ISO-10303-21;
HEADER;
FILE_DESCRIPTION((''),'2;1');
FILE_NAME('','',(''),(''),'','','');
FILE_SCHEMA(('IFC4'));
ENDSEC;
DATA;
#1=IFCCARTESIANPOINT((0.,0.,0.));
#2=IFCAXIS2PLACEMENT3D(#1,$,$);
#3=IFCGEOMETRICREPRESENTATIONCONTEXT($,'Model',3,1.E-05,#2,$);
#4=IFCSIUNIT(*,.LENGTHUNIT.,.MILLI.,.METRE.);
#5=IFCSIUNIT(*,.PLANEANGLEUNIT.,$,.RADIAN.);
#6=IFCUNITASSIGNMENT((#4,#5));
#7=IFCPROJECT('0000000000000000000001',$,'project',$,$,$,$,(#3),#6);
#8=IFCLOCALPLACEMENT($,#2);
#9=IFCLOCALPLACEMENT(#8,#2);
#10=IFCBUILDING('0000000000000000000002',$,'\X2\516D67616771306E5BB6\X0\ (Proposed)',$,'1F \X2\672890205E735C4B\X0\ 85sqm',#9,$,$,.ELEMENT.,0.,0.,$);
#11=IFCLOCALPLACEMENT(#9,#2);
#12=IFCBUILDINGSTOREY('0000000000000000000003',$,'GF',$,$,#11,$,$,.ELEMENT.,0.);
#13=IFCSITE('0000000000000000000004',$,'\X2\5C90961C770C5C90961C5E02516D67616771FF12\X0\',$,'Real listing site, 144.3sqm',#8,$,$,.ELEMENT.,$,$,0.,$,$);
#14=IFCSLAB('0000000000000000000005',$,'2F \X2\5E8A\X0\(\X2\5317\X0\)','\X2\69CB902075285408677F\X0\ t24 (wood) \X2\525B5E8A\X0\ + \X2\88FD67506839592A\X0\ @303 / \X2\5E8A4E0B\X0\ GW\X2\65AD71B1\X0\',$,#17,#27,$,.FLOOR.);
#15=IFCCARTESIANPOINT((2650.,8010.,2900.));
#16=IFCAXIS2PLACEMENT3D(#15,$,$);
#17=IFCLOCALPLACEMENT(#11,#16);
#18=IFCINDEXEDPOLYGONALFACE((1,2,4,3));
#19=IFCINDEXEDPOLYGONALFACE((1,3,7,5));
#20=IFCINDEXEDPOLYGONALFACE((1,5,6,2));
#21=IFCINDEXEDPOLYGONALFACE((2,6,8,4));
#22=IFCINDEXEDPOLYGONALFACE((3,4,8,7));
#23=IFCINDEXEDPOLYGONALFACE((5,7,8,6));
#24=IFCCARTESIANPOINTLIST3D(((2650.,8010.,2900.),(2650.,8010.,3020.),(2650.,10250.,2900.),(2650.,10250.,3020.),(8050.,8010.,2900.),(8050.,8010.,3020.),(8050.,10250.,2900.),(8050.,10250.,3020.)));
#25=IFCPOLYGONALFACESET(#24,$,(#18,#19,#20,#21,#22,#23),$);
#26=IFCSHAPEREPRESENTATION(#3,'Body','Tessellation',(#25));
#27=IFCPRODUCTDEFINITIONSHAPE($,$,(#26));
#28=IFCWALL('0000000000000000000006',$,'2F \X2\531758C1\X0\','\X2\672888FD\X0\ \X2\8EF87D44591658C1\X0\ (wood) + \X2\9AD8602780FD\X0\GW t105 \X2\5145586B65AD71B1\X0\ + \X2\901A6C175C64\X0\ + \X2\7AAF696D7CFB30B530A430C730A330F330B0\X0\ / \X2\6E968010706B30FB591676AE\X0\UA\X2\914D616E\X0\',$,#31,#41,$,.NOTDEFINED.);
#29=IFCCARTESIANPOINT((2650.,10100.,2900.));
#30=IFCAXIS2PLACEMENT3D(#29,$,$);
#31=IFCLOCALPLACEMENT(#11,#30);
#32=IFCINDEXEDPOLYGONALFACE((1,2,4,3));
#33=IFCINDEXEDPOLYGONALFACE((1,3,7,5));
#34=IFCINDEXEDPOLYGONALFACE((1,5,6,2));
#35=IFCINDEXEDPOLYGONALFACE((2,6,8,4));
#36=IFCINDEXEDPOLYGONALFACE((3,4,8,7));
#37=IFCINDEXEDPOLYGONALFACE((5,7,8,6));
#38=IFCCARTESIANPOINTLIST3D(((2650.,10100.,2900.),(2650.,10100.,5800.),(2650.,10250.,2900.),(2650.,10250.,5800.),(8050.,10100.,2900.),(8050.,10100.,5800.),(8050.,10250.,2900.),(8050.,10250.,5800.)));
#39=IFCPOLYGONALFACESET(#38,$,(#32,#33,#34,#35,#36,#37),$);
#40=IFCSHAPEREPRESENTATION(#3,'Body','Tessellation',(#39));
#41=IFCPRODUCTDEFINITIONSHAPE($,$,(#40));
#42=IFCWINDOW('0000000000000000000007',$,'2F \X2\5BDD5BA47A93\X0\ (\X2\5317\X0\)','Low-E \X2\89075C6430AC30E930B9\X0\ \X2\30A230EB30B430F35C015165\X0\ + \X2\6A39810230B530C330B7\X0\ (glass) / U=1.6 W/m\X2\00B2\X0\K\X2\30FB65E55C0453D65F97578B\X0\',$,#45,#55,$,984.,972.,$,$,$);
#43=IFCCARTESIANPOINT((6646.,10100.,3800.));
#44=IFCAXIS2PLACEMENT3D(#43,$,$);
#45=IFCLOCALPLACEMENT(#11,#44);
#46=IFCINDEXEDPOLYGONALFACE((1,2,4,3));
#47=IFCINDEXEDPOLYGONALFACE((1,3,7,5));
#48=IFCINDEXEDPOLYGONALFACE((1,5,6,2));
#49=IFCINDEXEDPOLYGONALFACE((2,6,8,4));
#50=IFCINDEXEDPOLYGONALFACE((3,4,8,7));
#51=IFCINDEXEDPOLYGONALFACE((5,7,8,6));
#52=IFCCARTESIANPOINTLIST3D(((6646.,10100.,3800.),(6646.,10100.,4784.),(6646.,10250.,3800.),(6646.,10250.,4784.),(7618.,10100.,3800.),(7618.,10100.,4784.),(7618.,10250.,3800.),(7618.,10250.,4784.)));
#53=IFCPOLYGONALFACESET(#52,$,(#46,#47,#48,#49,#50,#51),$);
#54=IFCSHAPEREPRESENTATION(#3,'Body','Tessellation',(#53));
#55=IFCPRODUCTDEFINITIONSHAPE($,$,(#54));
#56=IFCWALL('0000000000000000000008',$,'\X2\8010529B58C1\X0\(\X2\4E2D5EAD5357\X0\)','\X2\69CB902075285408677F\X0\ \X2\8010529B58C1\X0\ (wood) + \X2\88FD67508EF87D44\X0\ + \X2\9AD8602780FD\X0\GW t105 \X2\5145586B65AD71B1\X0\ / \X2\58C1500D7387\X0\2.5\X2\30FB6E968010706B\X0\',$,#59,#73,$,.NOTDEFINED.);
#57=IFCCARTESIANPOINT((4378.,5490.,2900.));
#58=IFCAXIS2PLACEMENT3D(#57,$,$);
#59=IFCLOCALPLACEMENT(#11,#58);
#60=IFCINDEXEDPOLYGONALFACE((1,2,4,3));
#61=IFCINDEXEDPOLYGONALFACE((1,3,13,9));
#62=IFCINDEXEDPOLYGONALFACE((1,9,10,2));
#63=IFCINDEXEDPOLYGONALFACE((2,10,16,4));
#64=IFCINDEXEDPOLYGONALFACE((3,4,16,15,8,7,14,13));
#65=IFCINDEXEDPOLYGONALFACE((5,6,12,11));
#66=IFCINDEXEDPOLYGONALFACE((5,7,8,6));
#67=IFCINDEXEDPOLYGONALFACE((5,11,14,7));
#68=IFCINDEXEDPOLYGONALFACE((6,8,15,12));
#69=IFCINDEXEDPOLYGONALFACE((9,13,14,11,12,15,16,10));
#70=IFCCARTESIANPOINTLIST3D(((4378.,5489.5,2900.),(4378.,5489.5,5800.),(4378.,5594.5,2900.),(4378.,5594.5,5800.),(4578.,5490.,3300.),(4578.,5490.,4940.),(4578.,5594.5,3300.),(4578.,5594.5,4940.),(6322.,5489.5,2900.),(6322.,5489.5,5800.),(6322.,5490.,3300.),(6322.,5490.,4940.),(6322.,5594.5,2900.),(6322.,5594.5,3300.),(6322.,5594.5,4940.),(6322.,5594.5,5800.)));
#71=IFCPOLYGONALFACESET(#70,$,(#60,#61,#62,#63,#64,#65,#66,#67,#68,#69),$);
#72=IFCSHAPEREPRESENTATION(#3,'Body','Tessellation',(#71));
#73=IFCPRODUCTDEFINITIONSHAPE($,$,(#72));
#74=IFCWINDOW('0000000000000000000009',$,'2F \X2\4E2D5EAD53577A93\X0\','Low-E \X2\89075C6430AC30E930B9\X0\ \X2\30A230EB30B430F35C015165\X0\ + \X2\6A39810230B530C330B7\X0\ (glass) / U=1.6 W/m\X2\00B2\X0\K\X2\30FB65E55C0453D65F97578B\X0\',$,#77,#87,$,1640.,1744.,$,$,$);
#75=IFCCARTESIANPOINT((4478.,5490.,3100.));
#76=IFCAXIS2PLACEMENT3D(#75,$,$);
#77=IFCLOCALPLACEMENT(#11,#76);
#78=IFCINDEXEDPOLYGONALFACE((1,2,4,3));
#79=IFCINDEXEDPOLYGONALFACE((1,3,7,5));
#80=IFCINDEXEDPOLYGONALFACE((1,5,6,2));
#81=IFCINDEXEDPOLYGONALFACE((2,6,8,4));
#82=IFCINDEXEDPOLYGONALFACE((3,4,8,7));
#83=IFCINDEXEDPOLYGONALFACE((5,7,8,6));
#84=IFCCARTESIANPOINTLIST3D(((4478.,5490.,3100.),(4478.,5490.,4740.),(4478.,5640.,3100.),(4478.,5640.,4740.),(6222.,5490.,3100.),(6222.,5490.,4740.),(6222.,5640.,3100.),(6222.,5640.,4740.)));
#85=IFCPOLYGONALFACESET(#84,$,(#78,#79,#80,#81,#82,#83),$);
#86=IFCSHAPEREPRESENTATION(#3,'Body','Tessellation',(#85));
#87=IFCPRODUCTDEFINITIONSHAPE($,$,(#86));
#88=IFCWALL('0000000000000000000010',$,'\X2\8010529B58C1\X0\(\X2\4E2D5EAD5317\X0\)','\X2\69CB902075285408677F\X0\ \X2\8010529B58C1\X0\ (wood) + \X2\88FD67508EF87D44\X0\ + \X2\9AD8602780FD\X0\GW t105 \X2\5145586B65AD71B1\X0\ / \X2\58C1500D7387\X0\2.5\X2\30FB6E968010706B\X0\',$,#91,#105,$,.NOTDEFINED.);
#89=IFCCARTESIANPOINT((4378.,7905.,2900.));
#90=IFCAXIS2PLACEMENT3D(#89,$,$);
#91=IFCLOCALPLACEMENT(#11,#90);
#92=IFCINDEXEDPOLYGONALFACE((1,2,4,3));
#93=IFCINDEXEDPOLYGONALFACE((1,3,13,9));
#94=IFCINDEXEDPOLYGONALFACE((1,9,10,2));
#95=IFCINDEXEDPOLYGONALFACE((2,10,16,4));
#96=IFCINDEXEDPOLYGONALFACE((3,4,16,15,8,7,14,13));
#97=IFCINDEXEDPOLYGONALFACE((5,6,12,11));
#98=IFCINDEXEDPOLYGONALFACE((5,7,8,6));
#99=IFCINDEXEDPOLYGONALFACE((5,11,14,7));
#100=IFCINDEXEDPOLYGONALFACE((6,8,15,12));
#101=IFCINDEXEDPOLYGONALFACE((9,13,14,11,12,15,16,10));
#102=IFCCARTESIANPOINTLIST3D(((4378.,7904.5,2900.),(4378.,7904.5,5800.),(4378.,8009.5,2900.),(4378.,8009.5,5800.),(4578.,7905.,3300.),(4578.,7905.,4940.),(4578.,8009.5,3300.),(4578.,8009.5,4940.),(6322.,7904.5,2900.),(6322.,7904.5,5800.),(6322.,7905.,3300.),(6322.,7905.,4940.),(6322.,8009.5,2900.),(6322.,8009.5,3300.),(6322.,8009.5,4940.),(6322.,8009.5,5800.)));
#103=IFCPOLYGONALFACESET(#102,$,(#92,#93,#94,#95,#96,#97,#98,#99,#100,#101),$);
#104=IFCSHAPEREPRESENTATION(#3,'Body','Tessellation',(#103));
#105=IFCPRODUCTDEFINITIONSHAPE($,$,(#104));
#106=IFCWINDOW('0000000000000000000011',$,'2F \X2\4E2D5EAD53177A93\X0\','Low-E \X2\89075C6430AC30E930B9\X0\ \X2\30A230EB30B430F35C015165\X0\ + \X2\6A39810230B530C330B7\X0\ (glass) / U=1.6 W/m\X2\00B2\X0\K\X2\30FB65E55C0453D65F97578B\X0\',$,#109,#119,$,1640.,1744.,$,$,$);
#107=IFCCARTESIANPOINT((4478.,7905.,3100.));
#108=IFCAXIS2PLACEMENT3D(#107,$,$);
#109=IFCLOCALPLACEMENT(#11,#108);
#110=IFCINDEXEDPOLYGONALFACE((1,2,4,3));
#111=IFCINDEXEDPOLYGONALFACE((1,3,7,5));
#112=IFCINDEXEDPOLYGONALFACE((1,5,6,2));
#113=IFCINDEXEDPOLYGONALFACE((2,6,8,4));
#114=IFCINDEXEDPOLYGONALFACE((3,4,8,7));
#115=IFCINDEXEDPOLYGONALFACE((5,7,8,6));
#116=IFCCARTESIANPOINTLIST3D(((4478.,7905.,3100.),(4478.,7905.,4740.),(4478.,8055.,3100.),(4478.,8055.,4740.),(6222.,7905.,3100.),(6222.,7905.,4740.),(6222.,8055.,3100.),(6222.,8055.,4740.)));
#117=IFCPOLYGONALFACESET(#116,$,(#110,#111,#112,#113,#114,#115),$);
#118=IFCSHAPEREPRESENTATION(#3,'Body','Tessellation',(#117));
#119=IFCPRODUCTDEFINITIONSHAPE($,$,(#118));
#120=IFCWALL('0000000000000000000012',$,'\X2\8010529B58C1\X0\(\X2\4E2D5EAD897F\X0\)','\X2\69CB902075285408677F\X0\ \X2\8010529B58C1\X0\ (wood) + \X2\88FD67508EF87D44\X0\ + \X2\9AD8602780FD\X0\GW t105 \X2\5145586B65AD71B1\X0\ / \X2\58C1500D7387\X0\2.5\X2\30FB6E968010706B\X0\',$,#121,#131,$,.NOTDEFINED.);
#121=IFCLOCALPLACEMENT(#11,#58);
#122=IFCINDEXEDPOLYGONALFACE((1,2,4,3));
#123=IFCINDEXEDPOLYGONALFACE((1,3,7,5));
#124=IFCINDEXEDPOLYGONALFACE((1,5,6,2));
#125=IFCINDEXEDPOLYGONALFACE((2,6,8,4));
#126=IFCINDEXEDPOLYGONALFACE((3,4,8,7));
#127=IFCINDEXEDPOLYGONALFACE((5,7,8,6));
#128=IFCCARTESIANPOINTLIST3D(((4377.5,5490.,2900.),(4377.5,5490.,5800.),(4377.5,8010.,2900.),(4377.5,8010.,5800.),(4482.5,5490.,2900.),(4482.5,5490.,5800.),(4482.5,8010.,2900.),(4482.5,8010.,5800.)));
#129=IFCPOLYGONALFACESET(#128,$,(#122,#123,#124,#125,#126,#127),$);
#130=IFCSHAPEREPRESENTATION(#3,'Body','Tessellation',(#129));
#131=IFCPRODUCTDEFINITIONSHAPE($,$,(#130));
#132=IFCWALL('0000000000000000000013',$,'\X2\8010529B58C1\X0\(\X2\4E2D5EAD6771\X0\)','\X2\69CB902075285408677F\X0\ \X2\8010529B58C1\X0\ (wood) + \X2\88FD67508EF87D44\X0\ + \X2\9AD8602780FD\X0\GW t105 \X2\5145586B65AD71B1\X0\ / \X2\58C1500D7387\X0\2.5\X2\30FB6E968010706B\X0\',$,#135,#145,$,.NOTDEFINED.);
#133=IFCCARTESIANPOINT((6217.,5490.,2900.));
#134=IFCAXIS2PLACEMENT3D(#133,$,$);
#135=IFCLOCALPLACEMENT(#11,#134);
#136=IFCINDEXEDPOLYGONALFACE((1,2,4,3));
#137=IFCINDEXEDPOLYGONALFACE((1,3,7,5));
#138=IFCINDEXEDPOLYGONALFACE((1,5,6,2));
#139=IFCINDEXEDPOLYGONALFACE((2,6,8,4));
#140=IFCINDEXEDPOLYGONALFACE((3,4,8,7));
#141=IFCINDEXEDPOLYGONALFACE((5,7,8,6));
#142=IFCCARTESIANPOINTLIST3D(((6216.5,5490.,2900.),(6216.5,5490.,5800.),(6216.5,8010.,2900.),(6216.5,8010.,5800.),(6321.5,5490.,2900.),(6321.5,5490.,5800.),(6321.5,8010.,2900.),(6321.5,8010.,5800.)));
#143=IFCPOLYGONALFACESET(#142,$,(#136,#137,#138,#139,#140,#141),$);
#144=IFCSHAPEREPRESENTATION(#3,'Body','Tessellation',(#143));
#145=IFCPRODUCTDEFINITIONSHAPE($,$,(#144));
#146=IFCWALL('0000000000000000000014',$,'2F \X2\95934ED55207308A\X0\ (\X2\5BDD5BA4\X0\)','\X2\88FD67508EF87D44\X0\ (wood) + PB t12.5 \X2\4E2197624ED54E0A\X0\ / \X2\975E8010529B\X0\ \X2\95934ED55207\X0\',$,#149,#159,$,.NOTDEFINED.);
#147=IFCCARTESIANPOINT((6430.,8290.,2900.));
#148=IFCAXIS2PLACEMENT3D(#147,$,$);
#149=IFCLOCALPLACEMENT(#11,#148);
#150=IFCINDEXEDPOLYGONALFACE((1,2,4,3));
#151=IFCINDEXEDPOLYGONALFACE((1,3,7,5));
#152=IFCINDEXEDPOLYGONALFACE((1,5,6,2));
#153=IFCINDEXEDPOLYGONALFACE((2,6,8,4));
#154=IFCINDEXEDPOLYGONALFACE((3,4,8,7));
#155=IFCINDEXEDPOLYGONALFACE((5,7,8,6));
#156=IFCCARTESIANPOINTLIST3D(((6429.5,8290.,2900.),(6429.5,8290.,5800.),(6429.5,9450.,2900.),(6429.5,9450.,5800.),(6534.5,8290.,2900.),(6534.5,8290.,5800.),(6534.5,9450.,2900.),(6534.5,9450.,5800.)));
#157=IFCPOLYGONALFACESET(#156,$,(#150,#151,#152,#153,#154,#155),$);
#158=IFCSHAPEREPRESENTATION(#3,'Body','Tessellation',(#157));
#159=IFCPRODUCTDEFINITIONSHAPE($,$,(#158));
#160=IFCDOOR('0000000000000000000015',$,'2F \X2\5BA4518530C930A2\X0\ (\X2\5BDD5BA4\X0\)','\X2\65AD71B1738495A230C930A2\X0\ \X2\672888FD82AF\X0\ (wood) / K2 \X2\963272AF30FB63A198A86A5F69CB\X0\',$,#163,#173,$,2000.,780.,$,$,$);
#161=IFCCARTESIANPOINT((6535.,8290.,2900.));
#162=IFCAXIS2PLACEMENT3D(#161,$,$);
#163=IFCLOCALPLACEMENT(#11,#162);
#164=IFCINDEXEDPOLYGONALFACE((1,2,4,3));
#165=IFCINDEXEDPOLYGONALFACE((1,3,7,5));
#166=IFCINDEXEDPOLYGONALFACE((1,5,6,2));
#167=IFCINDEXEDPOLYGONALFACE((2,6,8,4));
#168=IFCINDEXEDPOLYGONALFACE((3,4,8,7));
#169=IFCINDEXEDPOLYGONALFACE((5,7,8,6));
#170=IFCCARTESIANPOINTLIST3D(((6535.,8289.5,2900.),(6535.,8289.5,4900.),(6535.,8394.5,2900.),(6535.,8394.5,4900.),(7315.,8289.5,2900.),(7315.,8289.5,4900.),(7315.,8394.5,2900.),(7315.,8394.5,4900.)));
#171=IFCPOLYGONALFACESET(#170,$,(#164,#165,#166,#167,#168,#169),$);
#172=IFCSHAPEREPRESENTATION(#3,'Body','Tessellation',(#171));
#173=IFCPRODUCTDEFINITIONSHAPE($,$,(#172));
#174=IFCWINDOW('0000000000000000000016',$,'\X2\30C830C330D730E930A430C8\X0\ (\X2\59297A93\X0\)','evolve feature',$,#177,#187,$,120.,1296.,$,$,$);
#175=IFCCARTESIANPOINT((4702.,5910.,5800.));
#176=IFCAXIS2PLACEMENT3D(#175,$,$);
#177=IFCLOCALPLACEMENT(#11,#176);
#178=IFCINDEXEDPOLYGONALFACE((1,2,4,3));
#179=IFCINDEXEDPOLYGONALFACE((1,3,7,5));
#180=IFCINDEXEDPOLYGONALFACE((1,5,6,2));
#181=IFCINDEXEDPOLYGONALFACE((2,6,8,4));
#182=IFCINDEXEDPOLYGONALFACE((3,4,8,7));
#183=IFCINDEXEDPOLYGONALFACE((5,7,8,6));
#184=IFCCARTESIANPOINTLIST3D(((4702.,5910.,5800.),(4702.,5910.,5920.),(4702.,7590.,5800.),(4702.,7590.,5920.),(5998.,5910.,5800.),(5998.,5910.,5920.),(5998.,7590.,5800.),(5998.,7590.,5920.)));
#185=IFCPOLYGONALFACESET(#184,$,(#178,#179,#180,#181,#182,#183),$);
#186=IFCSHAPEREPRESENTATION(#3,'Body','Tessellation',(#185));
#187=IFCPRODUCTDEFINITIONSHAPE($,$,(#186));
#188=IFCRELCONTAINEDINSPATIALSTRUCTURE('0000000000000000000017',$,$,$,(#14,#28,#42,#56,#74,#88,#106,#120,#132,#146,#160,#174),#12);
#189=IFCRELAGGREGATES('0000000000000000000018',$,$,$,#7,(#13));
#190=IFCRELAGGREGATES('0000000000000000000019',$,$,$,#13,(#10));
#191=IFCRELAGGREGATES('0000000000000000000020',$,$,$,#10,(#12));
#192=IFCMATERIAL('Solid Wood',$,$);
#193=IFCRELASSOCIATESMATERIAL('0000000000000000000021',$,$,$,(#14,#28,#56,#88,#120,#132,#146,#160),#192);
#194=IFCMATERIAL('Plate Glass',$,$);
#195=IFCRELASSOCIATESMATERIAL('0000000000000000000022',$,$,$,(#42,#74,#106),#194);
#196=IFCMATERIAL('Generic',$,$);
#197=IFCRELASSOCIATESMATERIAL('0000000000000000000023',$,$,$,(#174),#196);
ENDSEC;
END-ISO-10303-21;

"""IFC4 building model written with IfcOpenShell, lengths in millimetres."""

from ifc_helpers import new_model, si_unit, frame, frame_2d, origin, place, context, project, spatial, rectangle, extrude, material, element, fill, save


model = new_model("IFC4")

# Units and contexts
model_context = context("Model", 3, precision=1e-05, world=origin())
ifc_project = project(units=[si_unit("LENGTHUNIT", "METRE", prefix="MILLI"), si_unit("PLANEANGLEUNIT", "RADIAN")], contexts=[model_context])

# Site, building, storey
site_placement = place(None, origin())
site = spatial("IfcSite", under=ifc_project, at=site_placement, Name="岐阜県岐阜市六条東２", ObjectType="Real listing site, 144.3sqm", CompositionType="ELEMENT", RefElevation=0.0)
building_placement = place(site_placement, origin())
building = spatial("IfcBuilding", under=site, at=building_placement, Name="六条東の家 (Proposed)", ObjectType="1F 木造平屋 85sqm", CompositionType="ELEMENT", ElevationOfRefHeight=0.0, ElevationOfTerrain=0.0)
storey_placement = place(building_placement, origin())
storey = spatial("IfcBuildingStorey", under=building, at=storey_placement, Name="GF", CompositionType="ELEMENT", Elevation=0.0)

# Slab
ifc_material_1 = material(Name="Solid Wood")
slab_placement = place(storey_placement, frame((2650.0, 8010.0, 2900.0)))
element("IfcSlab", 1, at=slab_placement, inside=storey, material=ifc_material_1, Name="2F 床(北)", Description="構造用合板 t24 (wood) 剛床 + 製材根太 @303 / 床下 GW断熱", PredefinedType="FLOOR", context=model_context, shape_type="SweptSolid", body=[
    extrude(rectangle(XDim=5400.0, YDim=2240.0, at=frame_2d((2700.0, 1120.0))), frame((2650.0, 8010.0, 2900.0)), (0.0, 0.0, 1.0), 120.0),
])

# Walls, openings, windows
wall_1_placement = place(storey_placement, frame((2650.0, 10100.0, 2900.0)))
wall_1 = element("IfcWall", 2, at=wall_1_placement, inside=storey, material=ifc_material_1, Name="2F 北壁", Description="木製 軸組外壁 (wood) + 高性能GW t105 充填断熱 + 通気層 + 窯業系サイディング / 準耐火・外皮UA配慮", PredefinedType="NOTDEFINED", context=model_context, shape_type="SweptSolid", body=[
    extrude(rectangle(XDim=5400.0, YDim=150.0, at=frame_2d((2700.0, 75.0))), frame((2650.0, 10100.0, 2900.0)), (0.0, 0.0, 1.0), 2900.0),
])
opening_1_placement = place(storey_placement, frame((6646.0, 10100.0, 3800.0)))
opening_1 = element("IfcOpeningElement", 3, at=opening_1_placement, cuts=wall_1, PredefinedType="NOTDEFINED", context=model_context, shape_type="SweptSolid", body=[
    extrude(rectangle(XDim=972.0, YDim=150.0, at=frame_2d((486.0, 75.0))), frame((6646.0, 10100.0, 3800.0)), (0.0, 0.0, 1.0), 984.0),
])
ifc_material_2 = material(Name="Plate Glass")
window_1_placement = place(storey_placement, frame((6646.0, 10100.0, 3800.0)))
window_1 = element("IfcWindow", 4, at=window_1_placement, inside=storey, material=ifc_material_2, Name="2F 寝室窓 (北)", Description="Low-E 複層ガラス アルゴン封入 + 樹脂サッシ (glass) / U=1.6 W/m²K・日射取得型", OverallHeight=984.0, OverallWidth=972.0, context=model_context, shape_type="SweptSolid", body=[
    extrude(rectangle(XDim=972.0, YDim=150.0, at=frame_2d((486.0, 75.0))), frame((6646.0, 10100.0, 3800.0)), (0.0, 0.0, 1.0), 984.0),
])
fill(opening_1, window_1)
wall_2_placement = place(storey_placement, frame((4378.0, 5490.0, 2900.0)))
wall_2 = element("IfcWall", 5, at=wall_2_placement, inside=storey, material=ifc_material_1, Name="耐力壁(中庭南)", Description="構造用合板 耐力壁 (wood) + 製材軸組 + 高性能GW t105 充填断熱 / 壁倍率2.5・準耐火", PredefinedType="NOTDEFINED", context=model_context, shape_type="SweptSolid", body=[
    extrude(rectangle(XDim=1944.0, YDim=105.0, at=frame_2d((972.0, 52.0))), frame((4378.0, 5490.0, 2900.0)), (0.0, 0.0, 1.0), 2900.0),
])
opening_2_placement = place(storey_placement, frame((4478.0, 5490.0, 3100.0)))
opening_2 = element("IfcOpeningElement", 6, at=opening_2_placement, cuts=wall_2, PredefinedType="NOTDEFINED", context=model_context, shape_type="SweptSolid", body=[
    extrude(rectangle(XDim=1744.0, YDim=150.0, at=frame_2d((872.0, 75.0))), frame((4478.0, 5490.0, 3100.0)), (0.0, 0.0, 1.0), 1640.0),
])
window_2_placement = place(storey_placement, frame((4478.0, 5490.0, 3100.0)))
window_2 = element("IfcWindow", 7, at=window_2_placement, inside=storey, material=ifc_material_2, Name="2F 中庭南窓", Description="Low-E 複層ガラス アルゴン封入 + 樹脂サッシ (glass) / U=1.6 W/m²K・日射取得型", OverallHeight=1640.0, OverallWidth=1744.0, context=model_context, shape_type="SweptSolid", body=[
    extrude(rectangle(XDim=1744.0, YDim=150.0, at=frame_2d((872.0, 75.0))), frame((4478.0, 5490.0, 3100.0)), (0.0, 0.0, 1.0), 1640.0),
])
fill(opening_2, window_2)
wall_3_placement = place(storey_placement, frame((4378.0, 7905.0, 2900.0)))
wall_3 = element("IfcWall", 8, at=wall_3_placement, inside=storey, material=ifc_material_1, Name="耐力壁(中庭北)", Description="構造用合板 耐力壁 (wood) + 製材軸組 + 高性能GW t105 充填断熱 / 壁倍率2.5・準耐火", PredefinedType="NOTDEFINED", context=model_context, shape_type="SweptSolid", body=[
    extrude(rectangle(XDim=1944.0, YDim=105.0, at=frame_2d((972.0, 52.0))), frame((4378.0, 7905.0, 2900.0)), (0.0, 0.0, 1.0), 2900.0),
])
opening_3_placement = place(storey_placement, frame((4478.0, 7905.0, 3100.0)))
opening_3 = element("IfcOpeningElement", 9, at=opening_3_placement, cuts=wall_3, PredefinedType="NOTDEFINED", context=model_context, shape_type="SweptSolid", body=[
    extrude(rectangle(XDim=1744.0, YDim=150.0, at=frame_2d((872.0, 75.0))), frame((4478.0, 7905.0, 3100.0)), (0.0, 0.0, 1.0), 1640.0),
])
window_3_placement = place(storey_placement, frame((4478.0, 7905.0, 3100.0)))
window_3 = element("IfcWindow", 10, at=window_3_placement, inside=storey, material=ifc_material_2, Name="2F 中庭北窓", Description="Low-E 複層ガラス アルゴン封入 + 樹脂サッシ (glass) / U=1.6 W/m²K・日射取得型", OverallHeight=1640.0, OverallWidth=1744.0, context=model_context, shape_type="SweptSolid", body=[
    extrude(rectangle(XDim=1744.0, YDim=150.0, at=frame_2d((872.0, 75.0))), frame((4478.0, 7905.0, 3100.0)), (0.0, 0.0, 1.0), 1640.0),
])
fill(opening_3, window_3)

# Walls
wall_4_placement = place(storey_placement, frame((4378.0, 5490.0, 2900.0)))
element("IfcWall", 11, at=wall_4_placement, inside=storey, material=ifc_material_1, Name="耐力壁(中庭西)", Description="構造用合板 耐力壁 (wood) + 製材軸組 + 高性能GW t105 充填断熱 / 壁倍率2.5・準耐火", PredefinedType="NOTDEFINED", context=model_context, shape_type="SweptSolid", body=[
    extrude(rectangle(XDim=105.0, YDim=2520.0, at=frame_2d((52.0, 1260.0))), frame((4378.0, 5490.0, 2900.0)), (0.0, 0.0, 1.0), 2900.0),
])
wall_5_placement = place(storey_placement, frame((6217.0, 5490.0, 2900.0)))
element("IfcWall", 12, at=wall_5_placement, inside=storey, material=ifc_material_1, Name="耐力壁(中庭東)", Description="構造用合板 耐力壁 (wood) + 製材軸組 + 高性能GW t105 充填断熱 / 壁倍率2.5・準耐火", PredefinedType="NOTDEFINED", context=model_context, shape_type="SweptSolid", body=[
    extrude(rectangle(XDim=105.0, YDim=2520.0, at=frame_2d((52.0, 1260.0))), frame((6217.0, 5490.0, 2900.0)), (0.0, 0.0, 1.0), 2900.0),
])
wall_6_placement = place(storey_placement, frame((6430.0, 8290.0, 2900.0)))
element("IfcWall", 13, at=wall_6_placement, inside=storey, material=ifc_material_1, Name="2F 間仕切り (寝室)", Description="製材軸組 (wood) + PB t12.5 両面仕上 / 非耐力 間仕切", PredefinedType="NOTDEFINED", context=model_context, shape_type="SweptSolid", body=[
    extrude(rectangle(XDim=105.0, YDim=1160.0, at=frame_2d((52.0, 580.0))), frame((6430.0, 8290.0, 2900.0)), (0.0, 0.0, 1.0), 2900.0),
])

# Door
door_placement = place(storey_placement, frame((6535.0, 8290.0, 2900.0)))
element("IfcDoor", 14, at=door_placement, inside=storey, material=ifc_material_1, Name="2F 室内ドア (寝室)", Description="断熱玄関ドア 木製芯 (wood) / K2 防犯・採風機構", OverallHeight=2000.0, OverallWidth=780.0, context=model_context, shape_type="SweptSolid", body=[
    extrude(rectangle(XDim=780.0, YDim=105.0, at=frame_2d((390.0, 52.0))), frame((6535.0, 8290.0, 2900.0)), (0.0, 0.0, 1.0), 2000.0),
])

# Window
ifc_material_3 = material(Name="Generic")
window_4_placement = place(storey_placement, frame((4702.0, 5910.0, 5800.0)))
element("IfcWindow", 15, at=window_4_placement, inside=storey, material=ifc_material_3, Name="トップライト (天窓)", Description="evolve feature", OverallHeight=120.0, OverallWidth=1296.0, context=model_context, shape_type="SweptSolid", body=[
    extrude(rectangle(XDim=1296.0, YDim=1680.0, at=frame_2d((648.0, 840.0))), frame((4702.0, 5910.0, 5800.0)), (0.0, 0.0, 1.0), 120.0),
])

save(model, "model.ifc")
